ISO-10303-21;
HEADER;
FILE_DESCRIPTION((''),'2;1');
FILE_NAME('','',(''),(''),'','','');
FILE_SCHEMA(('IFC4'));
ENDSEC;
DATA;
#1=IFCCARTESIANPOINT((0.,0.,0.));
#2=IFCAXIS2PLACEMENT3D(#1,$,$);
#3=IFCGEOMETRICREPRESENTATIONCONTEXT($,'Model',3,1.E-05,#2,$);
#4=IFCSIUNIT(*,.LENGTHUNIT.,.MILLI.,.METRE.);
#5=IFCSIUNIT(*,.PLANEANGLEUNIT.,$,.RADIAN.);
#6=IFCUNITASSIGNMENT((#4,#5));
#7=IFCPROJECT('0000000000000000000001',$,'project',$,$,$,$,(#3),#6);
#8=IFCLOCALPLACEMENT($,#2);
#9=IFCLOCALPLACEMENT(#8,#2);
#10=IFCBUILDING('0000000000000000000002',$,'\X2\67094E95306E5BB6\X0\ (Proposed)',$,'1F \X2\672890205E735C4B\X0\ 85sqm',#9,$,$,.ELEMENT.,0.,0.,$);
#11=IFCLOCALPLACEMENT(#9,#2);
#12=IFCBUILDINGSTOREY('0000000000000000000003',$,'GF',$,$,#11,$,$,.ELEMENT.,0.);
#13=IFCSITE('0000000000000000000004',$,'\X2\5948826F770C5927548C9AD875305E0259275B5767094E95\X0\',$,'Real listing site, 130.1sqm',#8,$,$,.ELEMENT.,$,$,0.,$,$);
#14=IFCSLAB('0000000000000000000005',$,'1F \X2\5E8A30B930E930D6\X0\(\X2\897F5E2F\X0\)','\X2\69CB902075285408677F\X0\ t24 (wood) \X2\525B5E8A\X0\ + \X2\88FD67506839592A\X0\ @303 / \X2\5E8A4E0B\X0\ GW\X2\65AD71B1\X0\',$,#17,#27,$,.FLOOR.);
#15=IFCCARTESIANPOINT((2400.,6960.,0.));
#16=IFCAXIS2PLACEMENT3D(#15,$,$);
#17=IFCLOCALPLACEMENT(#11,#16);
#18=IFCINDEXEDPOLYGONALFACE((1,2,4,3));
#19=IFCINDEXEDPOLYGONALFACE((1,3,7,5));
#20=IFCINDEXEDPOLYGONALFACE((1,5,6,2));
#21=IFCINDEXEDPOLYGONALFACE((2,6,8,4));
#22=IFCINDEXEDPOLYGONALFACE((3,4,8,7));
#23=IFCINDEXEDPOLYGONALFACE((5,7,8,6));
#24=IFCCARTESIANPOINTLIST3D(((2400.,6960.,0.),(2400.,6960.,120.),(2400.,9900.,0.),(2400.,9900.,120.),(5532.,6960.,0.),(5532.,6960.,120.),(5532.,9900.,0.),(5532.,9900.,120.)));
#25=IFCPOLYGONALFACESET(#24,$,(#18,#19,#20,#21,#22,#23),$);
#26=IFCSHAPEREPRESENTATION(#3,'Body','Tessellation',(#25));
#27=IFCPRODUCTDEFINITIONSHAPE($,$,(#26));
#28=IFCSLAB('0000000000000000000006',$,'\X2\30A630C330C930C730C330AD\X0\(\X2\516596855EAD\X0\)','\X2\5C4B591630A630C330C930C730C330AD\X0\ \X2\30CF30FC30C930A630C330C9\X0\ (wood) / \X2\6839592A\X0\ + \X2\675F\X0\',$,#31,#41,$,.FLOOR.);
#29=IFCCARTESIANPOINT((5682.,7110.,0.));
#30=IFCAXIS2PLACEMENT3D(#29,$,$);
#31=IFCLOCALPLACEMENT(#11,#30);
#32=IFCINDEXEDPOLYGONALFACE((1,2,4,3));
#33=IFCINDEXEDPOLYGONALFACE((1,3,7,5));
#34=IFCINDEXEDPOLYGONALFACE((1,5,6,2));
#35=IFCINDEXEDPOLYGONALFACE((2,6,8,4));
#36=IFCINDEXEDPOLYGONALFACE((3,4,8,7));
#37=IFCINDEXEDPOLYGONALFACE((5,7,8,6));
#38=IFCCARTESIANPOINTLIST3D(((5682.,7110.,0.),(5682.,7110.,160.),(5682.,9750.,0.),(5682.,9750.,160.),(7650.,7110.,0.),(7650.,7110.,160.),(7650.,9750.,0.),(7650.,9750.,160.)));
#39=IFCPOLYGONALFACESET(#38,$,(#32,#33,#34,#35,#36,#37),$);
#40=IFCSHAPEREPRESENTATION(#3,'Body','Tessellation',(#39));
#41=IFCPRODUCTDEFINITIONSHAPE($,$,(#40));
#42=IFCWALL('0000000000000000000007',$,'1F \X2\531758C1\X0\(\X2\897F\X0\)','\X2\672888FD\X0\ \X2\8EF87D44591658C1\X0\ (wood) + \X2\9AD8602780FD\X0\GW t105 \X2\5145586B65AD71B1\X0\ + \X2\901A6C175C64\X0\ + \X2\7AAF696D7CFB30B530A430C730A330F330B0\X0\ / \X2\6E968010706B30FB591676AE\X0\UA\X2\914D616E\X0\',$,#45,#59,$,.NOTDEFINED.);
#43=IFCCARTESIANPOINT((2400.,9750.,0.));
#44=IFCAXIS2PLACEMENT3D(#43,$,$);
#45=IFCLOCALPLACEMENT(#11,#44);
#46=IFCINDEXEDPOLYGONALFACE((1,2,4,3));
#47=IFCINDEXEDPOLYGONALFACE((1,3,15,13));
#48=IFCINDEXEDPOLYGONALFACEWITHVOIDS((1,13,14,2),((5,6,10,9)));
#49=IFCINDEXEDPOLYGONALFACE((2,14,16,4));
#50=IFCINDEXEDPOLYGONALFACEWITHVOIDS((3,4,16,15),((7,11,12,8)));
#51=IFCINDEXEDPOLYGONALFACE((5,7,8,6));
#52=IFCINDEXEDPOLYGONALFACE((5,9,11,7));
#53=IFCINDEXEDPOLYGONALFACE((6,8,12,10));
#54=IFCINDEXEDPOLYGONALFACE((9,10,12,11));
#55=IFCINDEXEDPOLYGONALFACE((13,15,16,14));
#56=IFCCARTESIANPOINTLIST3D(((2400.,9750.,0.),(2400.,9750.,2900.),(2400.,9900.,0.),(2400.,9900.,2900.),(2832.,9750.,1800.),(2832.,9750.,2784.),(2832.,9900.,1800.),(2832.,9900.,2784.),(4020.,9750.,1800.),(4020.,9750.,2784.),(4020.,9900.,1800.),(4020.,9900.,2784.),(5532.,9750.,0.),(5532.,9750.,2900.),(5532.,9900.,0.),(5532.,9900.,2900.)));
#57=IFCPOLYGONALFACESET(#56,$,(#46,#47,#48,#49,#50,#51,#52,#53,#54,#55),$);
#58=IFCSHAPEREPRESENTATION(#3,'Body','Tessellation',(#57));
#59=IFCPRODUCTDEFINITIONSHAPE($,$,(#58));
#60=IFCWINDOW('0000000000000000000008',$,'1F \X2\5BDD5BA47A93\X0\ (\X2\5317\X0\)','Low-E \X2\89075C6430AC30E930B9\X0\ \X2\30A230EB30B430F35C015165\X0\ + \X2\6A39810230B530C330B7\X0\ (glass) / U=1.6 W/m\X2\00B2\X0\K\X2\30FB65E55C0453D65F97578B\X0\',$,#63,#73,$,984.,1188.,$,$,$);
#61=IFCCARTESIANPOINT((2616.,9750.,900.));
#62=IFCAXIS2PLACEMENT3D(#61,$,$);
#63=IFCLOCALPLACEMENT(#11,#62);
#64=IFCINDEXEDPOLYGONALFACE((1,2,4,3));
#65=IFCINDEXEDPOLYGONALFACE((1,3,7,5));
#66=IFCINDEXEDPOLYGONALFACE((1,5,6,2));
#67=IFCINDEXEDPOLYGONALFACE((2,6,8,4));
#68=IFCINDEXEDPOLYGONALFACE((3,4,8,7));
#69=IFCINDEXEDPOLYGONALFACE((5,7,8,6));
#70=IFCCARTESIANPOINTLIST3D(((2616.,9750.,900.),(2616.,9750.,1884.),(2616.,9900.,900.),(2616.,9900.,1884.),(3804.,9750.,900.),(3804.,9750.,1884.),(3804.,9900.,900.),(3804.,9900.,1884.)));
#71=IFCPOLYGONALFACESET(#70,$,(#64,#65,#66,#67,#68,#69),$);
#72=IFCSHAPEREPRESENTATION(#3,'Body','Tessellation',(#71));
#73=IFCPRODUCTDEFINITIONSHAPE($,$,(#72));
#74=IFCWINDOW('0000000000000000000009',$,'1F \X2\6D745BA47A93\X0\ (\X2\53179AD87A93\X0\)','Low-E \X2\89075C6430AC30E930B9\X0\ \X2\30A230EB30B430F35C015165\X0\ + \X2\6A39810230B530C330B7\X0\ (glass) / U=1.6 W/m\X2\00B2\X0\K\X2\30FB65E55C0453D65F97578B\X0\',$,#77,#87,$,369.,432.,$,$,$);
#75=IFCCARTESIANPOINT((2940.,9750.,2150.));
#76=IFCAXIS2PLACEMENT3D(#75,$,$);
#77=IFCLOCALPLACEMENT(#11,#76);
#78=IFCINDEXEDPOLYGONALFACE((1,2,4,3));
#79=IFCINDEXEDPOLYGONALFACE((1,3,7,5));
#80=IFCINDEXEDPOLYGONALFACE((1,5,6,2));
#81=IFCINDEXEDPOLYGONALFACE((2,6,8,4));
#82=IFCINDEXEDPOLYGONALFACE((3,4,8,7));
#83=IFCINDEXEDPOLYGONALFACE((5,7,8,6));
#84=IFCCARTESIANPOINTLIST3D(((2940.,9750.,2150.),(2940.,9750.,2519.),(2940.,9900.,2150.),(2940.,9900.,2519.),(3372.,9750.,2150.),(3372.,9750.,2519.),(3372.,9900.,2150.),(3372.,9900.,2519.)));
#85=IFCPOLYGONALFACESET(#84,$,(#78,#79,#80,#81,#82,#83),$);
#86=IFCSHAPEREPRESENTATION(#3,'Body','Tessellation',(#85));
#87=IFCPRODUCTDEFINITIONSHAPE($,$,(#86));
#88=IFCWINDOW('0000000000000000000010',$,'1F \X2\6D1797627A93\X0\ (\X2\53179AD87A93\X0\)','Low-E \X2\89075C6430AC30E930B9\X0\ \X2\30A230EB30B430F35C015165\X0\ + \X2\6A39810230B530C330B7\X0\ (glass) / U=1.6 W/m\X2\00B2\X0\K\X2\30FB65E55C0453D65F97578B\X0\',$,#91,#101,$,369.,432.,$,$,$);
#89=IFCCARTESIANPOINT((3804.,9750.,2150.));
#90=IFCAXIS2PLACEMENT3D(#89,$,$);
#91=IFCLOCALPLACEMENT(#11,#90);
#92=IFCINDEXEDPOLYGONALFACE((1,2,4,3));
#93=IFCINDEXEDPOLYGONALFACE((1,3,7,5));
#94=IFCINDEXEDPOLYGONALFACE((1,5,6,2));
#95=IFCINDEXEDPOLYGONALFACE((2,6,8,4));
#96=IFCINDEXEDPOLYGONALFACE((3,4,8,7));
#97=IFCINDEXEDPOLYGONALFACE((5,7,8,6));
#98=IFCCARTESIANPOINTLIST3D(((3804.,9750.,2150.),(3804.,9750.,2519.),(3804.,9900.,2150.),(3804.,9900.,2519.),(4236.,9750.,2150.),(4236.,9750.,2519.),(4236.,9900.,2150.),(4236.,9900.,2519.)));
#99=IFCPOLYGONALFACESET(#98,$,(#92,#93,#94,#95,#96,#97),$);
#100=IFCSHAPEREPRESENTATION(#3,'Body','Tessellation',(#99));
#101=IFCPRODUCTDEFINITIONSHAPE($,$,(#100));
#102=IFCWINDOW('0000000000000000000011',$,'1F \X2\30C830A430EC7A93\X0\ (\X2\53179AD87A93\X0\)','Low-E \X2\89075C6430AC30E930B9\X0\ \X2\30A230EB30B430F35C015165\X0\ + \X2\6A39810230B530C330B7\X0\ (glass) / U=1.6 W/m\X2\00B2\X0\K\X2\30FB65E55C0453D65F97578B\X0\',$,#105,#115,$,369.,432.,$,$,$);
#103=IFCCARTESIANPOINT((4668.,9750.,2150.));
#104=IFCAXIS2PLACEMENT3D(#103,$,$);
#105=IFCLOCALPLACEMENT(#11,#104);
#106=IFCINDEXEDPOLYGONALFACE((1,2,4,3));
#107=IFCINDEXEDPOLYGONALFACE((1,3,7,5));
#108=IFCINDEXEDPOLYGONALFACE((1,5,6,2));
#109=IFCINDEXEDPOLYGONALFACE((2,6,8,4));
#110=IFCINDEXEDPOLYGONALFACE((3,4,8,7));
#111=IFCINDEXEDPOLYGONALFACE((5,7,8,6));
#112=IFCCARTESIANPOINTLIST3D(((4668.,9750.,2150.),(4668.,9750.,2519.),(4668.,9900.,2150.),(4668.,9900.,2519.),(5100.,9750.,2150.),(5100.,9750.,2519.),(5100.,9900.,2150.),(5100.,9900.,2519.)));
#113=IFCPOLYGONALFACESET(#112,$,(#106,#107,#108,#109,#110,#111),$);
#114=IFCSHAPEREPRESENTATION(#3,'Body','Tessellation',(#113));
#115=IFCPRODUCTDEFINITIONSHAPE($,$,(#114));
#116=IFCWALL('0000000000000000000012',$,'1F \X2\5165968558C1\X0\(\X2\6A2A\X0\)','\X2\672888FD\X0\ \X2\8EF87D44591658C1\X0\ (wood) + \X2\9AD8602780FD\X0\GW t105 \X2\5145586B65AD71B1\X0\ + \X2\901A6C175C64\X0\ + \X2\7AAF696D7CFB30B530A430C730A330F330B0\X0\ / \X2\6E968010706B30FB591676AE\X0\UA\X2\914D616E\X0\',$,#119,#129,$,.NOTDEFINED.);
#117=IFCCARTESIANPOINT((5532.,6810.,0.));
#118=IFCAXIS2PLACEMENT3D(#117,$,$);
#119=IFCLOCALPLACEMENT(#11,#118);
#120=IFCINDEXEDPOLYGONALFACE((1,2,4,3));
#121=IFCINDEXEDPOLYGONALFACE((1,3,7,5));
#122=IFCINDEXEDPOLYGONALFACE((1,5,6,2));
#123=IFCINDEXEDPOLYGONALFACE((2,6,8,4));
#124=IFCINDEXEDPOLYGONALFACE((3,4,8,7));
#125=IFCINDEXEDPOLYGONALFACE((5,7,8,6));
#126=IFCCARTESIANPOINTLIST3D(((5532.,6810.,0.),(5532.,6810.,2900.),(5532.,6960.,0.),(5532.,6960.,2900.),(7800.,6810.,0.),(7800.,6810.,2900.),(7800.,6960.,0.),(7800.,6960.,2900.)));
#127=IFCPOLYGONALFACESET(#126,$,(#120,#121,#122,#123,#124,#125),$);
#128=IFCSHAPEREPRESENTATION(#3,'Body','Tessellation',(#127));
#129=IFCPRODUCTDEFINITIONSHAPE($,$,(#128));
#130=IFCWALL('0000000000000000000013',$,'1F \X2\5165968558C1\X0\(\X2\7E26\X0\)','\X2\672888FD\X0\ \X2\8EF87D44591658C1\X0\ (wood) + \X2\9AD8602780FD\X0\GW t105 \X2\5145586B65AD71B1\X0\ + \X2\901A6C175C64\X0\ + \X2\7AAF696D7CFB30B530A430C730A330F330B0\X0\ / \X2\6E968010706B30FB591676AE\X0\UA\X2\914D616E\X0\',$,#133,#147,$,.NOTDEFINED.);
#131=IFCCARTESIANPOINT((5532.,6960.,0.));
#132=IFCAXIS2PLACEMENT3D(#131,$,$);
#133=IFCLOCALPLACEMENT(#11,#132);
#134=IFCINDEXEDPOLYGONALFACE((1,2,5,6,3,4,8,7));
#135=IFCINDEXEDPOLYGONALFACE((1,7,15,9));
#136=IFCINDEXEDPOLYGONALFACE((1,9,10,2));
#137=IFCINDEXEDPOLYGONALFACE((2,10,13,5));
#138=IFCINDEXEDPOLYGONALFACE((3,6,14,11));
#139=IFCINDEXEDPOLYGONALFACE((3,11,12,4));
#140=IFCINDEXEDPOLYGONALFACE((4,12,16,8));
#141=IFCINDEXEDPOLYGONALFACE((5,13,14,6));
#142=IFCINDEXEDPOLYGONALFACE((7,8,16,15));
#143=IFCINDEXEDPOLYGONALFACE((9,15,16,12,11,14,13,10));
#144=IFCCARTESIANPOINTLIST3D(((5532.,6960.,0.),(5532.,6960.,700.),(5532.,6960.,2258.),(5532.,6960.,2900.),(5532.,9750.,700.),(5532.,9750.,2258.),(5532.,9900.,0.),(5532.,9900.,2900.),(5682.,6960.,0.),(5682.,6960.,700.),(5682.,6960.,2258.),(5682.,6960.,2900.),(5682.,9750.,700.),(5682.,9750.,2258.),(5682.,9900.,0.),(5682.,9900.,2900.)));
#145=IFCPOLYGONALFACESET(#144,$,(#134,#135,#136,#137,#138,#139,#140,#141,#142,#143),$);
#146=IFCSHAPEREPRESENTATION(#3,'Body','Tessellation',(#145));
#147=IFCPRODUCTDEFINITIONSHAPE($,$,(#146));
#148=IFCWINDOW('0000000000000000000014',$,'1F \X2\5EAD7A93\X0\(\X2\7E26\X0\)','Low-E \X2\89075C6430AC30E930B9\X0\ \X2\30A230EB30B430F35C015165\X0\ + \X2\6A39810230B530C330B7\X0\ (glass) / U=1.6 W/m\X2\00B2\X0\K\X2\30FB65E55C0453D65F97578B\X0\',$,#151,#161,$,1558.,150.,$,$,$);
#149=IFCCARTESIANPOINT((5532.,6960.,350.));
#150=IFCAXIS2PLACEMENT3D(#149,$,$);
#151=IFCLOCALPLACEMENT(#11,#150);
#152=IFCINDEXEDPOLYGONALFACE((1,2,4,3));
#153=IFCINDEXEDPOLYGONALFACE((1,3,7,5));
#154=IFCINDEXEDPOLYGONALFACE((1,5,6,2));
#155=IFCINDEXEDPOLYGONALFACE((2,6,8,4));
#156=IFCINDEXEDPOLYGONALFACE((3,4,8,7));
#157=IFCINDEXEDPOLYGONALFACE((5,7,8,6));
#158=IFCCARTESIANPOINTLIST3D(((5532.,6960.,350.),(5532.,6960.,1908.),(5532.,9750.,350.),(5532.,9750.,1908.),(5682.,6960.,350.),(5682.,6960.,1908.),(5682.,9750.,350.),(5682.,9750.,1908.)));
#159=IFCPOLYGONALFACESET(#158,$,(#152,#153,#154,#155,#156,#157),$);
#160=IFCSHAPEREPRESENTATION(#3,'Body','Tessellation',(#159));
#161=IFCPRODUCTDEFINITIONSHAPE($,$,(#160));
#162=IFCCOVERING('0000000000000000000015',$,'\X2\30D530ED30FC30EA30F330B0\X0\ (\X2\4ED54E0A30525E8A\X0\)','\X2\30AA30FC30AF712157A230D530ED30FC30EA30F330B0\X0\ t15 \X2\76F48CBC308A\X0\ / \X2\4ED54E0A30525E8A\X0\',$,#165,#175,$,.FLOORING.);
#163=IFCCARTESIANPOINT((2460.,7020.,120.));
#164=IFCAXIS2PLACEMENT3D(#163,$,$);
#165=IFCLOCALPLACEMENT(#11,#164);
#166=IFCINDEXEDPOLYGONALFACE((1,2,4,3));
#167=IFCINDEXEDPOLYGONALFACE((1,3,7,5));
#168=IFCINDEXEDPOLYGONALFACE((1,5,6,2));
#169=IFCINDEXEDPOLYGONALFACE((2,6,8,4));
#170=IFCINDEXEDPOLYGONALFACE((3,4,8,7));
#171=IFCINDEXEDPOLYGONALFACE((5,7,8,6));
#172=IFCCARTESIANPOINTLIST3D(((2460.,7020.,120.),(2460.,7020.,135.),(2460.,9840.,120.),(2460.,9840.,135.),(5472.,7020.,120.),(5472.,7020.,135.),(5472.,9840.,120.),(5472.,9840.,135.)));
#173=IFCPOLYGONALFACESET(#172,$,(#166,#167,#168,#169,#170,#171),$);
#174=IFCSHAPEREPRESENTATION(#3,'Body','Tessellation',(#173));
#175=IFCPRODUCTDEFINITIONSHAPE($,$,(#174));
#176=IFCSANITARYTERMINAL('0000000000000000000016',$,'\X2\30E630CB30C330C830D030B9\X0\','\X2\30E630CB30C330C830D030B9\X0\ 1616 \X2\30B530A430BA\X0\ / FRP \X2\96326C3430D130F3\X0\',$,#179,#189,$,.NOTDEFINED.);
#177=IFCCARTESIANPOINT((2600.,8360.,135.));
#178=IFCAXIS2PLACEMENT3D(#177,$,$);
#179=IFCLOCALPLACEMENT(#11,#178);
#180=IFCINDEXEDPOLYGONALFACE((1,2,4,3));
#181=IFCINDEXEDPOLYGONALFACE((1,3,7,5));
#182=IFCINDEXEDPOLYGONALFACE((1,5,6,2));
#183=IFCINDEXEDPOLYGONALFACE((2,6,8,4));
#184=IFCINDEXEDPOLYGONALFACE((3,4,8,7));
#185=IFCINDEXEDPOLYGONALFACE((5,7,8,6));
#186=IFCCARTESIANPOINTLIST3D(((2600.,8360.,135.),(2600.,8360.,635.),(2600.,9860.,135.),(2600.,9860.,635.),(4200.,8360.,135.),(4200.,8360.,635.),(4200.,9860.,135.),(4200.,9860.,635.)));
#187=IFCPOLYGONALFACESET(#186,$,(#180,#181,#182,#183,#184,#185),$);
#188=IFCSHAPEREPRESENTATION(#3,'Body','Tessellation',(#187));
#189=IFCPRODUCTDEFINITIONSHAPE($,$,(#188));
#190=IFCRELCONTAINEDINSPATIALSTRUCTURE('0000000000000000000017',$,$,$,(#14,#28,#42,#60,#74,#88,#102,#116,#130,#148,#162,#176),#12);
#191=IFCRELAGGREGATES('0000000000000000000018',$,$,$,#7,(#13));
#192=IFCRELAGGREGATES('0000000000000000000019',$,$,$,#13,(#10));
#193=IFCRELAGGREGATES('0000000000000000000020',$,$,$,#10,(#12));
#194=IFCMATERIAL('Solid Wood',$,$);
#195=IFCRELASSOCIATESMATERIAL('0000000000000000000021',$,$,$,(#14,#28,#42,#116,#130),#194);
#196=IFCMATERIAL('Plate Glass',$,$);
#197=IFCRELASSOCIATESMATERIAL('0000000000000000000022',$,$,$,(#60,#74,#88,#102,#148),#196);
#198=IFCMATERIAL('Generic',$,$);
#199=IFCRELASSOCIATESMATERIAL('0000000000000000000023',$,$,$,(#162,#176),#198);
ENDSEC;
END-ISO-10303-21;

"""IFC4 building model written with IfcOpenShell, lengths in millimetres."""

from ifc_helpers import new_model, si_unit, frame, frame_2d, origin, place, context, project, spatial, rectangle, extrude, material, element, fill, save


model = new_model("IFC4")

# Units and contexts
model_context = context("Model", 3, precision=1e-05, world=origin())
ifc_project = project(units=[si_unit("LENGTHUNIT", "METRE", prefix="MILLI"), si_unit("PLANEANGLEUNIT", "RADIAN")], contexts=[model_context])

# Site, building, storey
site_placement = place(None, origin())
site = spatial("IfcSite", under=ifc_project, at=site_placement, Name="奈良県大和高田市大字有井", ObjectType="Real listing site, 130.1sqm", CompositionType="ELEMENT", RefElevation=0.0)
building_placement = place(site_placement, origin())
building = spatial("IfcBuilding", under=site, at=building_placement, Name="有井の家 (Proposed)", ObjectType="1F 木造平屋 85sqm", CompositionType="ELEMENT", ElevationOfRefHeight=0.0, ElevationOfTerrain=0.0)
storey_placement = place(building_placement, origin())
storey = spatial("IfcBuildingStorey", under=building, at=storey_placement, Name="GF", CompositionType="ELEMENT", Elevation=0.0)

# Slabs
ifc_material_1 = material(Name="Solid Wood")
slab_1_placement = place(storey_placement, frame((2400.0, 6960.0, 0.0)))
element("IfcSlab", 1, at=slab_1_placement, inside=storey, material=ifc_material_1, Name="1F 床スラブ(西帯)", Description="構造用合板 t24 (wood) 剛床 + 製材根太 @303 / 床下 GW断熱", PredefinedType="FLOOR", context=model_context, shape_type="SweptSolid", body=[
    extrude(rectangle(XDim=3132.0, YDim=2940.0, at=frame_2d((1566.0, 1470.0))), frame((2400.0, 6960.0, 0.0)), (0.0, 0.0, 1.0), 120.0),
])
slab_2_placement = place(storey_placement, frame((5682.0, 7110.0, 0.0)))
element("IfcSlab", 2, at=slab_2_placement, inside=storey, material=ifc_material_1, Name="ウッドデッキ(入隅庭)", Description="屋外ウッドデッキ ハードウッド (wood) / 根太 + 束", PredefinedType="FLOOR", context=model_context, shape_type="SweptSolid", body=[
    extrude(rectangle(XDim=1968.0, YDim=2640.0, at=frame_2d((984.0, 1320.0))), frame((5682.0, 7110.0, 0.0)), (0.0, 0.0, 1.0), 160.0),
])

# Wall, openings, windows
wall_1_placement = place(storey_placement, frame((2400.0, 9750.0, 0.0)))
wall_1 = element("IfcWall", 3, at=wall_1_placement, inside=storey, material=ifc_material_1, Name="1F 北壁(西)", Description="木製 軸組外壁 (wood) + 高性能GW t105 充填断熱 + 通気層 + 窯業系サイディング / 準耐火・外皮UA配慮", PredefinedType="NOTDEFINED", context=model_context, shape_type="SweptSolid", body=[
    extrude(rectangle(XDim=3132.0, YDim=150.0, at=frame_2d((1566.0, 75.0))), frame((2400.0, 9750.0, 0.0)), (0.0, 0.0, 1.0), 2900.0),
])
opening_1_placement = place(storey_placement, frame((2616.0, 9750.0, 900.0)))
opening_1 = element("IfcOpeningElement", 4, at=opening_1_placement, cuts=wall_1, PredefinedType="NOTDEFINED", context=model_context, shape_type="SweptSolid", body=[
    extrude(rectangle(XDim=1188.0, YDim=150.0, at=frame_2d((594.0, 75.0))), frame((2616.0, 9750.0, 900.0)), (0.0, 0.0, 1.0), 984.0),
])
opening_2_placement = place(storey_placement, frame((2940.0, 9750.0, 2150.0)))
opening_2 = element("IfcOpeningElement", 5, at=opening_2_placement, cuts=wall_1, PredefinedType="NOTDEFINED", context=model_context, shape_type="SweptSolid", body=[
    extrude(rectangle(XDim=432.0, YDim=150.0, at=frame_2d((216.0, 75.0))), frame((2940.0, 9750.0, 2150.0)), (0.0, 0.0, 1.0), 369.0),
])
opening_3_placement = place(storey_placement, frame((3804.0, 9750.0, 2150.0)))
opening_3 = element("IfcOpeningElement", 6, at=opening_3_placement, cuts=wall_1, PredefinedType="NOTDEFINED", context=model_context, shape_type="SweptSolid", body=[
    extrude(rectangle(XDim=432.0, YDim=150.0, at=frame_2d((216.0, 75.0))), frame((3804.0, 9750.0, 2150.0)), (0.0, 0.0, 1.0), 369.0),
])
opening_4_placement = place(storey_placement, frame((4668.0, 9750.0, 2150.0)))
opening_4 = element("IfcOpeningElement", 7, at=opening_4_placement, cuts=wall_1, PredefinedType="NOTDEFINED", context=model_context, shape_type="SweptSolid", body=[
    extrude(rectangle(XDim=432.0, YDim=150.0, at=frame_2d((216.0, 75.0))), frame((4668.0, 9750.0, 2150.0)), (0.0, 0.0, 1.0), 369.0),
])
ifc_material_2 = material(Name="Plate Glass")
window_1_placement = place(storey_placement, frame((2616.0, 9750.0, 900.0)))
window_1 = element("IfcWindow", 8, at=window_1_placement, inside=storey, material=ifc_material_2, Name="1F 寝室窓 (北)", Description="Low-E 複層ガラス アルゴン封入 + 樹脂サッシ (glass) / U=1.6 W/m²K・日射取得型", OverallHeight=984.0, OverallWidth=1188.0, context=model_context, shape_type="SweptSolid", body=[
    extrude(rectangle(XDim=1188.0, YDim=150.0, at=frame_2d((594.0, 75.0))), frame((2616.0, 9750.0, 900.0)), (0.0, 0.0, 1.0), 984.0),
])
fill(opening_1, window_1)
window_2_placement = place(storey_placement, frame((2940.0, 9750.0, 2150.0)))
window_2 = element("IfcWindow", 9, at=window_2_placement, inside=storey, material=ifc_material_2, Name="1F 浴室窓 (北高窓)", Description="Low-E 複層ガラス アルゴン封入 + 樹脂サッシ (glass) / U=1.6 W/m²K・日射取得型", OverallHeight=369.0, OverallWidth=432.0, context=model_context, shape_type="SweptSolid", body=[
    extrude(rectangle(XDim=432.0, YDim=150.0, at=frame_2d((216.0, 75.0))), frame((2940.0, 9750.0, 2150.0)), (0.0, 0.0, 1.0), 369.0),
])
fill(opening_2, window_2)
window_3_placement = place(storey_placement, frame((3804.0, 9750.0, 2150.0)))
window_3 = element("IfcWindow", 10, at=window_3_placement, inside=storey, material=ifc_material_2, Name="1F 洗面窓 (北高窓)", Description="Low-E 複層ガラス アルゴン封入 + 樹脂サッシ (glass) / U=1.6 W/m²K・日射取得型", OverallHeight=369.0, OverallWidth=432.0, context=model_context, shape_type="SweptSolid", body=[
    extrude(rectangle(XDim=432.0, YDim=150.0, at=frame_2d((216.0, 75.0))), frame((3804.0, 9750.0, 2150.0)), (0.0, 0.0, 1.0), 369.0),
])
fill(opening_3, window_3)
window_4_placement = place(storey_placement, frame((4668.0, 9750.0, 2150.0)))
window_4 = element("IfcWindow", 11, at=window_4_placement, inside=storey, material=ifc_material_2, Name="1F トイレ窓 (北高窓)", Description="Low-E 複層ガラス アルゴン封入 + 樹脂サッシ (glass) / U=1.6 W/m²K・日射取得型", OverallHeight=369.0, OverallWidth=432.0, context=model_context, shape_type="SweptSolid", body=[
    extrude(rectangle(XDim=432.0, YDim=150.0, at=frame_2d((216.0, 75.0))), frame((4668.0, 9750.0, 2150.0)), (0.0, 0.0, 1.0), 369.0),
])
fill(opening_4, window_4)

# Wall
wall_2_placement = place(storey_placement, frame((5532.0, 6810.0, 0.0)))
element("IfcWall", 12, at=wall_2_placement, inside=storey, material=ifc_material_1, Name="1F 入隅壁(横)", Description="木製 軸組外壁 (wood) + 高性能GW t105 充填断熱 + 通気層 + 窯業系サイディング / 準耐火・外皮UA配慮", PredefinedType="NOTDEFINED", context=model_context, shape_type="SweptSolid", body=[
    extrude(rectangle(XDim=2268.0, YDim=150.0, at=frame_2d((1134.0, 75.0))), frame((5532.0, 6810.0, 0.0)), (0.0, 0.0, 1.0), 2900.0),
])

# Wall, opening, window
wall_3_placement = place(storey_placement, frame((5532.0, 6960.0, 0.0)))
wall_3 = element("IfcWall", 13, at=wall_3_placement, inside=storey, material=ifc_material_1, Name="1F 入隅壁(縦)", Description="木製 軸組外壁 (wood) + 高性能GW t105 充填断熱 + 通気層 + 窯業系サイディング / 準耐火・外皮UA配慮", PredefinedType="NOTDEFINED", context=model_context, shape_type="SweptSolid", body=[
    extrude(rectangle(XDim=150.0, YDim=2940.0, at=frame_2d((75.0, 1470.0))), frame((5532.0, 6960.0, 0.0)), (0.0, 0.0, 1.0), 2900.0),
])
opening_5_placement = place(storey_placement, frame((5532.0, 6960.0, 350.0)))
opening_5 = element("IfcOpeningElement", 14, at=opening_5_placement, cuts=wall_3, PredefinedType="NOTDEFINED", context=model_context, shape_type="SweptSolid", body=[
    extrude(rectangle(XDim=150.0, YDim=2790.0, at=frame_2d((75.0, 1395.0))), frame((5532.0, 6960.0, 350.0)), (0.0, 0.0, 1.0), 1558.0),
])
window_5_placement = place(storey_placement, frame((5532.0, 6960.0, 350.0)))
window_5 = element("IfcWindow", 15, at=window_5_placement, inside=storey, material=ifc_material_2, Name="1F 庭窓(縦)", Description="Low-E 複層ガラス アルゴン封入 + 樹脂サッシ (glass) / U=1.6 W/m²K・日射取得型", OverallHeight=1558.0, OverallWidth=150.0, context=model_context, shape_type="SweptSolid", body=[
    extrude(rectangle(XDim=150.0, YDim=2790.0, at=frame_2d((75.0, 1395.0))), frame((5532.0, 6960.0, 350.0)), (0.0, 0.0, 1.0), 1558.0),
])
fill(opening_5, window_5)

# Covering
ifc_material_3 = material(Name="Generic")
covering_placement = place(storey_placement, frame((2460.0, 7020.0, 120.0)))
element("IfcCovering", 16, at=covering_placement, inside=storey, material=ifc_material_3, Name="フローリング (仕上げ床)", Description="オーク無垢フローリング t15 直貼り / 仕上げ床", PredefinedType="FLOORING", context=model_context, shape_type="SweptSolid", body=[
    extrude(rectangle(XDim=3012.0, YDim=2820.0, at=frame_2d((1506.0, 1410.0))), frame((2460.0, 7020.0, 120.0)), (0.0, 0.0, 1.0), 15.0),
])

# Sanitary terminal
sanitary_terminal_1_placement = place(storey_placement, frame((2600.0, 8360.0, 135.0)))
element("IfcSanitaryTerminal", 17, at=sanitary_terminal_1_placement, inside=storey, material=ifc_material_3, Name="ユニットバス", Description="ユニットバス 1616 サイズ / FRP 防水パン", PredefinedType="NOTDEFINED", context=model_context, shape_type="SweptSolid", body=[
    extrude(rectangle(XDim=1600.0, YDim=1500.0, at=frame_2d((800.0, 750.0))), frame((2600.0, 8360.0, 135.0)), (0.0, 0.0, 1.0), 500.0),
])

save(model, "model.ifc")
